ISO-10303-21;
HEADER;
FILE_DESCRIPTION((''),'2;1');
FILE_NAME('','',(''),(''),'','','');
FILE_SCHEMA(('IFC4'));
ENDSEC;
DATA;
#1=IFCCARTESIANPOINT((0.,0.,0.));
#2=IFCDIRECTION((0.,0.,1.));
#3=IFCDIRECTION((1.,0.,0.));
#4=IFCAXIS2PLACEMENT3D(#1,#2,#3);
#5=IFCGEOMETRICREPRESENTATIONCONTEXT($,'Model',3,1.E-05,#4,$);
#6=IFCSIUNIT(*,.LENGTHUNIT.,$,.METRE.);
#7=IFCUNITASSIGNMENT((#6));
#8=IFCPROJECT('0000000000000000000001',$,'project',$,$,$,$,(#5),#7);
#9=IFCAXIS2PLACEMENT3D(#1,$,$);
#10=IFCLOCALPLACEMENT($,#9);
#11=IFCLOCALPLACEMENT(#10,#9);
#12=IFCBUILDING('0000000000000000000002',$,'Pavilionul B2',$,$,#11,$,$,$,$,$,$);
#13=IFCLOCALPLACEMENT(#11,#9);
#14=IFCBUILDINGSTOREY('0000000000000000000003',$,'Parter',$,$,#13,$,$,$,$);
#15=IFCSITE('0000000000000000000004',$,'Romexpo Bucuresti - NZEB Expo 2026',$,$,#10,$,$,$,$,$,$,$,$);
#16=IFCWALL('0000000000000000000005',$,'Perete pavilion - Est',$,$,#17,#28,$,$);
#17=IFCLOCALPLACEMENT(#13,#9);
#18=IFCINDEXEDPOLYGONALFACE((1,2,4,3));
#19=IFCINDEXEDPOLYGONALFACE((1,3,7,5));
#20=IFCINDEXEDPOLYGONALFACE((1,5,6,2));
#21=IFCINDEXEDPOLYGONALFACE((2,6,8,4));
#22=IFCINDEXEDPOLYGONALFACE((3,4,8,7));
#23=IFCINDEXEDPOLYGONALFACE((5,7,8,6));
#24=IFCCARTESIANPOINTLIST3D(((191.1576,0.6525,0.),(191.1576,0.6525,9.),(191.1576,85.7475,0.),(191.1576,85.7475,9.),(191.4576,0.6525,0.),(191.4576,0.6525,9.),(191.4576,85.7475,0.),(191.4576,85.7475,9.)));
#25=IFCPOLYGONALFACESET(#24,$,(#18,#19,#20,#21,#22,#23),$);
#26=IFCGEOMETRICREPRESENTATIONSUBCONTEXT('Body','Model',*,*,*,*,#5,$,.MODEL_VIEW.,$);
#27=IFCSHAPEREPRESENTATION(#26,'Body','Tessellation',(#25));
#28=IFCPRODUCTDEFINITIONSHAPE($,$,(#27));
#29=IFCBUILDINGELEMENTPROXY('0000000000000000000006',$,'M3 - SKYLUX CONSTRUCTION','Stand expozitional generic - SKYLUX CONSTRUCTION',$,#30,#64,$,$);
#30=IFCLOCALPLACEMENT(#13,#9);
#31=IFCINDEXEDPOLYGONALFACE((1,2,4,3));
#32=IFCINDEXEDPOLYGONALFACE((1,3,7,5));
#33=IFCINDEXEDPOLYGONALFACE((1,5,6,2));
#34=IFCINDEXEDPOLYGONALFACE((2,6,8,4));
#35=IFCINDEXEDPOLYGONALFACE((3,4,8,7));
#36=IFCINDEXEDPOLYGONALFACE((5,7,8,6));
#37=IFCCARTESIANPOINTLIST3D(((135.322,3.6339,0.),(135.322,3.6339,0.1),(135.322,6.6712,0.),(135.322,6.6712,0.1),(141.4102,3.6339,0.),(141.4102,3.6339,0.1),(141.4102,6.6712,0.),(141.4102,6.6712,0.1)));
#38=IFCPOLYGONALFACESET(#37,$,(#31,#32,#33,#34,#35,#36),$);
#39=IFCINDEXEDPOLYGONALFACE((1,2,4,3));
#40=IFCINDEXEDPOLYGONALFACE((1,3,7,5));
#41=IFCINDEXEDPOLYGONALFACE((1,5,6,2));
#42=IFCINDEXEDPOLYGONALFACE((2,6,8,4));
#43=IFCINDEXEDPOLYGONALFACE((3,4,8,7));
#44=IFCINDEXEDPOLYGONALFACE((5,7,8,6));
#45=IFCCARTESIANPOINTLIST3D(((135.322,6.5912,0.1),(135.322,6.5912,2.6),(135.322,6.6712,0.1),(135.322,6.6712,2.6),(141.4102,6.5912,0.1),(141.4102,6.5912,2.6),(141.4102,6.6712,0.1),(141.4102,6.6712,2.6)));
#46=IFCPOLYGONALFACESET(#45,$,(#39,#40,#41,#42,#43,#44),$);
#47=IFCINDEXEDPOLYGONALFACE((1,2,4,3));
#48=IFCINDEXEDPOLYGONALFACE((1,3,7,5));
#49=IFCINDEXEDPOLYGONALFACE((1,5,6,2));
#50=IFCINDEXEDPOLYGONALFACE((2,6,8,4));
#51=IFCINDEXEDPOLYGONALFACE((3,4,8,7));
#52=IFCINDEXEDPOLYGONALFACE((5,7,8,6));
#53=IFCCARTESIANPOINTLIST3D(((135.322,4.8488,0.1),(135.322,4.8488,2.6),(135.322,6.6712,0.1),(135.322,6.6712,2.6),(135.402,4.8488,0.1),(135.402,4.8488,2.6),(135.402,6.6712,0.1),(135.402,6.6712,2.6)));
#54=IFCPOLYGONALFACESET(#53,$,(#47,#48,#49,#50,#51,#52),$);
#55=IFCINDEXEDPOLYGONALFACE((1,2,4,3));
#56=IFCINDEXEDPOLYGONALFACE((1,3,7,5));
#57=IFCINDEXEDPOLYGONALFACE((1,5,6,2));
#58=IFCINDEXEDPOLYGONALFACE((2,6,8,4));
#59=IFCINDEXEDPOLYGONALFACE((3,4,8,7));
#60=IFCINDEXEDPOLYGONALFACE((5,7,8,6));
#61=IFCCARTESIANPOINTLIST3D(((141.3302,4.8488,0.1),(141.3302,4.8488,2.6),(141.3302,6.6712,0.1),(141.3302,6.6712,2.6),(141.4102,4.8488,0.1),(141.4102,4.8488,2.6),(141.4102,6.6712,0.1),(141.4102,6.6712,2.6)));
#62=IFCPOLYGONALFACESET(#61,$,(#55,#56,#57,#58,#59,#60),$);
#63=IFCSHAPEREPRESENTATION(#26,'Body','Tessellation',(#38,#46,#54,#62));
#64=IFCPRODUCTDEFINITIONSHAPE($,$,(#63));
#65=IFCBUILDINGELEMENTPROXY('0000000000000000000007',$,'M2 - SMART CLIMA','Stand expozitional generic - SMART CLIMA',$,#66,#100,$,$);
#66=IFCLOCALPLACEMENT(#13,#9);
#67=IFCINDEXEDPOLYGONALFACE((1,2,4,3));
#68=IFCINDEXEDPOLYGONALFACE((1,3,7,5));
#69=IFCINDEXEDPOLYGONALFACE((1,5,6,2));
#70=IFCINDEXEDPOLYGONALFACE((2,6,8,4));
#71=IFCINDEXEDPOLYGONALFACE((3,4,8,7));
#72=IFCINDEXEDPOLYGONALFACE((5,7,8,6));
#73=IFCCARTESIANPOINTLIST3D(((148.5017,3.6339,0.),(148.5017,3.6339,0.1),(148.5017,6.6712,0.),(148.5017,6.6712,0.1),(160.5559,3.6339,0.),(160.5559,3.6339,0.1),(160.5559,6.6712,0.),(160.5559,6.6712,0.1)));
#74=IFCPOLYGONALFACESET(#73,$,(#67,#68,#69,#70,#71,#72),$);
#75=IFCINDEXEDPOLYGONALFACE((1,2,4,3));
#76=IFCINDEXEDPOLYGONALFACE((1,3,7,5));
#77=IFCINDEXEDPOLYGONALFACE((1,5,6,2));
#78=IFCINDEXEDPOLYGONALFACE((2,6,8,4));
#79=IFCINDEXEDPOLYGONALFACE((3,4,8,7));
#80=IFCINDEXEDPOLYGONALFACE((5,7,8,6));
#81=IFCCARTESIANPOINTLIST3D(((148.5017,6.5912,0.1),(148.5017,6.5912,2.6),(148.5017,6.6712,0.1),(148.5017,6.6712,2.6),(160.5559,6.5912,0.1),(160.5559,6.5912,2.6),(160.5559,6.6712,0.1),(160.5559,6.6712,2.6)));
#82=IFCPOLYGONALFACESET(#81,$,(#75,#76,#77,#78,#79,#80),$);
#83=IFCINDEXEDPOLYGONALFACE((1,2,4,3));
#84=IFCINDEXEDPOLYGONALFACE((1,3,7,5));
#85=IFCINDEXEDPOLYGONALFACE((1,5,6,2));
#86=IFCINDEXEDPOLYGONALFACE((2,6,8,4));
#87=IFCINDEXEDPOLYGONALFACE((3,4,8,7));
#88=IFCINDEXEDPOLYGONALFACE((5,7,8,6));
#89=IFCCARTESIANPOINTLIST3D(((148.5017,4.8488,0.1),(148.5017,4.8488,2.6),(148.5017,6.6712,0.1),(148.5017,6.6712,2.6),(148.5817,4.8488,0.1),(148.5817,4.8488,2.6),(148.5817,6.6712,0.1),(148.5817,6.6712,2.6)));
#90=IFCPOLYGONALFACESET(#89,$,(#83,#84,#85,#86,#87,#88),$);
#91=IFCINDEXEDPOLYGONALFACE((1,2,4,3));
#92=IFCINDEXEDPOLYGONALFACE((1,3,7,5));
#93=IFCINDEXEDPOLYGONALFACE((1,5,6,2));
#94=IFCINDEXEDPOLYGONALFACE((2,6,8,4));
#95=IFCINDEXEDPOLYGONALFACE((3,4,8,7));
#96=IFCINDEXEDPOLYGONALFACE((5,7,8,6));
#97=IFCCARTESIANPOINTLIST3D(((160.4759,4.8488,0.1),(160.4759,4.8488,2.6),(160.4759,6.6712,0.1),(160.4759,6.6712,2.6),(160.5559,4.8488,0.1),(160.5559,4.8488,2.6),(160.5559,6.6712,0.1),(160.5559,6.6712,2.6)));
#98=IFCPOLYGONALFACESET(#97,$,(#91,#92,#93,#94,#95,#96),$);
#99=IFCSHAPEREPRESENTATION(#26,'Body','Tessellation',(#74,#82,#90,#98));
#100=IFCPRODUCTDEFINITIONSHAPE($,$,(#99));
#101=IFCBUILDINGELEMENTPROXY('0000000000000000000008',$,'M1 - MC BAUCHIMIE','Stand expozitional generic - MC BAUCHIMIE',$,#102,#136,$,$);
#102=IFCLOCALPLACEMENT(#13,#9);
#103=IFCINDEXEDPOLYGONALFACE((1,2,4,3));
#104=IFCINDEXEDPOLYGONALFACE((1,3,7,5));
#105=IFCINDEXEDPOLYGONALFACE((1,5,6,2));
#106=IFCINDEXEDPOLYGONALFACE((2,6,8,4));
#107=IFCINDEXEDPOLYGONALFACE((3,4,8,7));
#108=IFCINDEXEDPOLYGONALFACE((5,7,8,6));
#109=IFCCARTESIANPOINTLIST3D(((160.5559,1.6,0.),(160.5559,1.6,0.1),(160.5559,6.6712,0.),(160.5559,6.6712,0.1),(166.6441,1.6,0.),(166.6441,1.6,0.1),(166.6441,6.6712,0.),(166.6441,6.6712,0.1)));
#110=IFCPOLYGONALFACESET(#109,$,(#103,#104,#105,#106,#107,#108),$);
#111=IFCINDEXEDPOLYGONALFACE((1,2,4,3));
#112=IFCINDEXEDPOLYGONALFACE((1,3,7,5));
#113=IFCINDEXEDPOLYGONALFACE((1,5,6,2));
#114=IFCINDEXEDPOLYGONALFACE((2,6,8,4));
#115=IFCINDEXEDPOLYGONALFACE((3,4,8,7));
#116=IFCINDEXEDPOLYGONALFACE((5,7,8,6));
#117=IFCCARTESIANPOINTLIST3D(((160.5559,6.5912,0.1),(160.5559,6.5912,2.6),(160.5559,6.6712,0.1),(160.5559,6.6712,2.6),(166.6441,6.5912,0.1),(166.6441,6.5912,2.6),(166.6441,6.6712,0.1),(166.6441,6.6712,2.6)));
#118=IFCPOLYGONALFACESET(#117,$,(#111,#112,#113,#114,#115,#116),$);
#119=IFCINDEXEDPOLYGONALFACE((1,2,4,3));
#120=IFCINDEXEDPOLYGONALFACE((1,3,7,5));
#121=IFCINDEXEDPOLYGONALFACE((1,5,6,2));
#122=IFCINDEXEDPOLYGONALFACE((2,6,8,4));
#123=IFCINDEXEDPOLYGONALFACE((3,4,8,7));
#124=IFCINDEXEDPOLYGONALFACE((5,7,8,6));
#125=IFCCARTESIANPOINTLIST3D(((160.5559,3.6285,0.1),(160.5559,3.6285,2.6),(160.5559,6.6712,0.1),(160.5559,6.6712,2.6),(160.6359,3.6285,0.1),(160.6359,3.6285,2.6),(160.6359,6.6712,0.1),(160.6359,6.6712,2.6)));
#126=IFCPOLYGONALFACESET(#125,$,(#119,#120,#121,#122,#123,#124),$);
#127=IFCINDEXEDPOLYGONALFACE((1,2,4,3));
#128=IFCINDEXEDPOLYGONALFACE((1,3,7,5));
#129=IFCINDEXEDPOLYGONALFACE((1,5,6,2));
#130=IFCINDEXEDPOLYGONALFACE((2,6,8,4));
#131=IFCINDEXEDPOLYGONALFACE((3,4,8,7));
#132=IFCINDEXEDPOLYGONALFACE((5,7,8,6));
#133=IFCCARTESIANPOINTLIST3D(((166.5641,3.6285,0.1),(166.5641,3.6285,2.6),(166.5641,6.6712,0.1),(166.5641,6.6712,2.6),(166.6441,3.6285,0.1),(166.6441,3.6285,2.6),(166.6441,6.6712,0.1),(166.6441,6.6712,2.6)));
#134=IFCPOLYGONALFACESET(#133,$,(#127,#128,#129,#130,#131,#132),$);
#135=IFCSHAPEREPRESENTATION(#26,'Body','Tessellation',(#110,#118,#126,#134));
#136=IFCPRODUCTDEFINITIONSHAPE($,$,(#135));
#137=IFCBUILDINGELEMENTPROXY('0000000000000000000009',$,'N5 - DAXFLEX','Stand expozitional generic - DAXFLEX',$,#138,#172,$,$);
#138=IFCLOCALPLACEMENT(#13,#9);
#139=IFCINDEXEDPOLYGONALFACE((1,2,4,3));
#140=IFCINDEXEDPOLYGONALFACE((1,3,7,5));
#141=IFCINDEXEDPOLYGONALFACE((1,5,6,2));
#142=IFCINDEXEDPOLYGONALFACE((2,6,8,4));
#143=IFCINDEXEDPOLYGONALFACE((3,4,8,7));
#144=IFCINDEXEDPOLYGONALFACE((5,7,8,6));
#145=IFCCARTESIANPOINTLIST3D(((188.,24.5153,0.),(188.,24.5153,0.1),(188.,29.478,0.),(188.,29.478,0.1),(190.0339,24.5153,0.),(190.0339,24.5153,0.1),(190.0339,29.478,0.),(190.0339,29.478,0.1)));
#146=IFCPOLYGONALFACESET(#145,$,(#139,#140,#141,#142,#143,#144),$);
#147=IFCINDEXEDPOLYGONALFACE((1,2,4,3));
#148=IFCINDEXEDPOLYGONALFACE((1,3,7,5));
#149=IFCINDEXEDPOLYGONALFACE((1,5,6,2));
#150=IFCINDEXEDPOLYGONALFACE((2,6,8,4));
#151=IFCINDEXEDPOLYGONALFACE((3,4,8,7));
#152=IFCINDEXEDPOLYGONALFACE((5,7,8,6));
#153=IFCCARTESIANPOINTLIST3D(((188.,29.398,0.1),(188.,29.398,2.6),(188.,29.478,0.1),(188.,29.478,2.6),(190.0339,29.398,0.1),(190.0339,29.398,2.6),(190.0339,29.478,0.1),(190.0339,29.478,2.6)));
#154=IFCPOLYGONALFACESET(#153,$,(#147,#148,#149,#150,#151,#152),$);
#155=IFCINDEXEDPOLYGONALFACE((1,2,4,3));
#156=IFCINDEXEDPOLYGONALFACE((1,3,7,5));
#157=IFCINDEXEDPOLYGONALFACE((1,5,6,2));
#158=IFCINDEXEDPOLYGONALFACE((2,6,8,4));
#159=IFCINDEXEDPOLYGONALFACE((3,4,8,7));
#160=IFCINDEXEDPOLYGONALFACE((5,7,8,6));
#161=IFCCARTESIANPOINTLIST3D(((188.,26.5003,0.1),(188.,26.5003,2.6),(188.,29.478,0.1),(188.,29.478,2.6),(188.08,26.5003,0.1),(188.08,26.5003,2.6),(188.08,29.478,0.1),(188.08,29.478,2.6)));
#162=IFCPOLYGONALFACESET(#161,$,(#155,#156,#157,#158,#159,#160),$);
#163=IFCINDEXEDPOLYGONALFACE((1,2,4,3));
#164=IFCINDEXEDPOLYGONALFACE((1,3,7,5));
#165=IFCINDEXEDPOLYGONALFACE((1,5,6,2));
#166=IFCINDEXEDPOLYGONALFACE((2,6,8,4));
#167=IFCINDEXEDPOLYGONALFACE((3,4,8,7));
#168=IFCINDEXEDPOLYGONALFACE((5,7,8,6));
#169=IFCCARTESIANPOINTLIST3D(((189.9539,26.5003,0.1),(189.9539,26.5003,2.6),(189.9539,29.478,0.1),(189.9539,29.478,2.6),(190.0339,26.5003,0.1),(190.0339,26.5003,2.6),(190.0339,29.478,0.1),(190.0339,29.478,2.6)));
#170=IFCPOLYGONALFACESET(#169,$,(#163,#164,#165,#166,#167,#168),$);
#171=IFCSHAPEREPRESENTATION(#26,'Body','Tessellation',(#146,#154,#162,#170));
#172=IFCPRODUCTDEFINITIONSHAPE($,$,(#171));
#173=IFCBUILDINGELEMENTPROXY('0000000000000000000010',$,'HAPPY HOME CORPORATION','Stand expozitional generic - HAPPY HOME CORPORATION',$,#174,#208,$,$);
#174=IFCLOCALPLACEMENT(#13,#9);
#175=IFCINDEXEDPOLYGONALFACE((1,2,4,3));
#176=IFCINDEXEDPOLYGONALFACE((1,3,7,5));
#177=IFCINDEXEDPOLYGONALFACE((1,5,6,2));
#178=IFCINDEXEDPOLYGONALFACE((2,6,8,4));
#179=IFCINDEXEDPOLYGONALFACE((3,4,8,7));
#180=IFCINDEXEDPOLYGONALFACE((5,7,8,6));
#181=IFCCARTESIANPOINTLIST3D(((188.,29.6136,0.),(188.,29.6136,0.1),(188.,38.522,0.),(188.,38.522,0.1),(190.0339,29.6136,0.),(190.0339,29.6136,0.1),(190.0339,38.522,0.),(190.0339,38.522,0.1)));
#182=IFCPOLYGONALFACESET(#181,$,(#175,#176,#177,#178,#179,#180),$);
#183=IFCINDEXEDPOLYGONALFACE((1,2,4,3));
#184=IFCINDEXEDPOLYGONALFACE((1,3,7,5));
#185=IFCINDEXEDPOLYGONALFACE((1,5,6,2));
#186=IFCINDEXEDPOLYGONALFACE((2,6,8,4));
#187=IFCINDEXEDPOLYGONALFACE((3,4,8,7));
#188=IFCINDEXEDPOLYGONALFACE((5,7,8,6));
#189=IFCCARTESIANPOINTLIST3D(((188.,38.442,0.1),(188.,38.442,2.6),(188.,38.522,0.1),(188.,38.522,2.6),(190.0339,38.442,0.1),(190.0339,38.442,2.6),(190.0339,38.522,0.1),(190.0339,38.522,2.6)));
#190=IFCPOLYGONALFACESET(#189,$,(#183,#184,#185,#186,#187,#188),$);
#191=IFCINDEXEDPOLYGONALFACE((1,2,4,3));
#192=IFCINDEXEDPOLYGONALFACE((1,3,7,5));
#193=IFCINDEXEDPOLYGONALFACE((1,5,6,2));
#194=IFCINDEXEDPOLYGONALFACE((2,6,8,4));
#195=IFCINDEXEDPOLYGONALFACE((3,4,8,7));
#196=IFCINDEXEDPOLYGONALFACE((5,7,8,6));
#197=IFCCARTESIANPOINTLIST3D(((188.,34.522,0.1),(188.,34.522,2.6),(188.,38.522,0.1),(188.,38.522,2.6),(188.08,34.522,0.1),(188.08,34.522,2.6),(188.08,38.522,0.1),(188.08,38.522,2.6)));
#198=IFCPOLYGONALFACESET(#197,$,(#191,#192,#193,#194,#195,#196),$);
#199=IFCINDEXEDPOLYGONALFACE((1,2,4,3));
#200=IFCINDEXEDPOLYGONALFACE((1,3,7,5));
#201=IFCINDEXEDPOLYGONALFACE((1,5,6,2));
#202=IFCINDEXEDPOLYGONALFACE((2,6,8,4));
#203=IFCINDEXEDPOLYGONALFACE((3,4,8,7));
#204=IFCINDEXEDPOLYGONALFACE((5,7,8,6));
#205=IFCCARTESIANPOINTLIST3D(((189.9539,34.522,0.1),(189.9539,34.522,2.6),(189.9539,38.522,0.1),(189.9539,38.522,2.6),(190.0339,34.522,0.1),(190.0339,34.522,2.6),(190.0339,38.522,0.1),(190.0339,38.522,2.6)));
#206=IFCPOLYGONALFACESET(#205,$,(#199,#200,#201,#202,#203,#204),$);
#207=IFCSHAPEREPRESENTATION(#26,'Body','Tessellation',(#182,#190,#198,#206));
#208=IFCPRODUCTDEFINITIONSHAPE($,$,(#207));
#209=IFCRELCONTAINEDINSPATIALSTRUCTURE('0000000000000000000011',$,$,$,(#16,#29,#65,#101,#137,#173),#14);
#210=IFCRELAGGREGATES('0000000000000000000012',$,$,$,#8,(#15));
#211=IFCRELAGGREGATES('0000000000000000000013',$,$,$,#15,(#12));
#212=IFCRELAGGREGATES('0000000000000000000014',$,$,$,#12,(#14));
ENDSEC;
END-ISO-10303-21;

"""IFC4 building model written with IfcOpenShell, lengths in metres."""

from ifc_helpers import new_model, si_unit, frame, frame_2d, origin, origin_with_axes, place, context, subcontext, project, spatial, rectangle, extrude, element, save


model = new_model("IFC4")

# Units and contexts
model_context = context("Model", 3, precision=1e-05, world=origin_with_axes())
body_context = subcontext(model_context, "Body", "Model", "MODEL_VIEW")
ifc_project = project(units=[si_unit("LENGTHUNIT", "METRE")], contexts=[model_context])

# Site, building, storey
site_placement = place(None, origin())
site = spatial("IfcSite", under=ifc_project, at=site_placement, Name="Romexpo Bucuresti - NZEB Expo 2026")
building_placement = place(site_placement, origin())
building = spatial("IfcBuilding", under=site, at=building_placement, Name="Pavilionul B2")
storey_placement = place(building_placement, origin())
storey = spatial("IfcBuildingStorey", under=building, at=storey_placement, Name="Parter")

# Wall
wall_placement = place(storey_placement, frame((191.1576, 0.6525, 0.0), z_axis=(0.0, 0.0, 1.0), x_axis=(1.0, 0.0, 0.0)))
element("IfcWall", 1, at=wall_placement, inside=storey, Name="Perete pavilion - Est", context=body_context, shape_type="SweptSolid", body=[
    extrude(rectangle(XDim=0.3, YDim=85.0949, at=frame_2d((0.15, 42.5475))), origin(), (0.0, 0.0, 1.0), 9.0),
])

# Building element proxies
proxy_1_placement = place(storey_placement, frame((135.322, 3.6339, 0.0), z_axis=(0.0, 0.0, 1.0), x_axis=(1.0, 0.0, 0.0)))
element("IfcBuildingElementProxy", 2, at=proxy_1_placement, inside=storey, Name="M3 - SKYLUX CONSTRUCTION", Description="Stand expozitional generic - SKYLUX CONSTRUCTION", context=body_context, shape_type="SweptSolid", body=[
    extrude(rectangle(XDim=6.0881, YDim=3.0373, at=frame_2d((3.0441, 1.5186))), origin(), (0.0, 0.0, 1.0), 0.1),
    extrude(rectangle(XDim=6.0881, YDim=0.08, at=frame_2d((3.0441, 2.9973))), frame((0.0, 0.0, 0.1)), (0.0, 0.0, 1.0), 2.5),
    extrude(rectangle(XDim=0.08, YDim=1.8224, at=frame_2d((0.04, 2.1261))), frame((0.0, 0.0, 0.1)), (0.0, 0.0, 1.0), 2.5),
    extrude(rectangle(XDim=0.08, YDim=1.8224, at=frame_2d((6.0481, 2.1261))), frame((0.0, 0.0, 0.1)), (0.0, 0.0, 1.0), 2.5),
])
proxy_2_placement = place(storey_placement, frame((148.5017, 3.6339, 0.0), z_axis=(0.0, 0.0, 1.0), x_axis=(1.0, 0.0, 0.0)))
element("IfcBuildingElementProxy", 3, at=proxy_2_placement, inside=storey, Name="M2 - SMART CLIMA", Description="Stand expozitional generic - SMART CLIMA", context=body_context, shape_type="SweptSolid", body=[
    extrude(rectangle(XDim=12.0542, YDim=3.0373, at=frame_2d((6.0271, 1.5186))), origin(), (0.0, 0.0, 1.0), 0.1),
    extrude(rectangle(XDim=12.0542, YDim=0.08, at=frame_2d((6.0271, 2.9973))), frame((0.0, 0.0, 0.1)), (0.0, 0.0, 1.0), 2.5),
    extrude(rectangle(XDim=0.08, YDim=1.8224, at=frame_2d((0.04, 2.1261))), frame((0.0, 0.0, 0.1)), (0.0, 0.0, 1.0), 2.5),
    extrude(rectangle(XDim=0.08, YDim=1.8224, at=frame_2d((12.0142, 2.1261))), frame((0.0, 0.0, 0.1)), (0.0, 0.0, 1.0), 2.5),
])
proxy_3_placement = place(storey_placement, frame((160.5559, 1.6, 0.0), z_axis=(0.0, 0.0, 1.0), x_axis=(1.0, 0.0, 0.0)))
element("IfcBuildingElementProxy", 4, at=proxy_3_placement, inside=storey, Name="M1 - MC BAUCHIMIE", Description="Stand expozitional generic - MC BAUCHIMIE", context=body_context, shape_type="SweptSolid", body=[
    extrude(rectangle(XDim=6.0881, YDim=5.0712, at=frame_2d((3.0441, 2.5356))), origin(), (0.0, 0.0, 1.0), 0.1),
    extrude(rectangle(XDim=6.0881, YDim=0.08, at=frame_2d((3.0441, 5.0312))), frame((0.0, 0.0, 0.1)), (0.0, 0.0, 1.0), 2.5),
    extrude(rectangle(XDim=0.08, YDim=3.0427, at=frame_2d((0.04, 3.5498))), frame((0.0, 0.0, 0.1)), (0.0, 0.0, 1.0), 2.5),
    extrude(rectangle(XDim=0.08, YDim=3.0427, at=frame_2d((6.0481, 3.5498))), frame((0.0, 0.0, 0.1)), (0.0, 0.0, 1.0), 2.5),
])
proxy_4_placement = place(storey_placement, frame((188.0, 24.5153, 0.0), z_axis=(0.0, 0.0, 1.0), x_axis=(1.0, 0.0, 0.0)))
element("IfcBuildingElementProxy", 5, at=proxy_4_placement, inside=storey, Name="N5 - DAXFLEX", Description="Stand expozitional generic - DAXFLEX", context=body_context, shape_type="SweptSolid", body=[
    extrude(rectangle(XDim=2.0339, YDim=4.9627, at=frame_2d((1.0169, 2.4814))), origin(), (0.0, 0.0, 1.0), 0.1),
    extrude(rectangle(XDim=2.0339, YDim=0.08, at=frame_2d((1.0169, 4.9227))), frame((0.0, 0.0, 0.1)), (0.0, 0.0, 1.0), 2.5),
    extrude(rectangle(XDim=0.08, YDim=2.9776, at=frame_2d((0.04, 3.4739))), frame((0.0, 0.0, 0.1)), (0.0, 0.0, 1.0), 2.5),
    extrude(rectangle(XDim=0.08, YDim=2.9776, at=frame_2d((1.9939, 3.4739))), frame((0.0, 0.0, 0.1)), (0.0, 0.0, 1.0), 2.5),
])
proxy_5_placement = place(storey_placement, frame((188.0, 29.6136, 0.0), z_axis=(0.0, 0.0, 1.0), x_axis=(1.0, 0.0, 0.0)))
element("IfcBuildingElementProxy", 6, at=proxy_5_placement, inside=storey, Name="HAPPY HOME CORPORATION", Description="Stand expozitional generic - HAPPY HOME CORPORATION", context=body_context, shape_type="SweptSolid", body=[
    extrude(rectangle(XDim=2.0339, YDim=8.9085, at=frame_2d((1.0169, 4.4542))), origin(), (0.0, 0.0, 1.0), 0.1),
    extrude(rectangle(XDim=2.0339, YDim=0.08, at=frame_2d((1.0169, 8.8685))), frame((0.0, 0.0, 0.1)), (0.0, 0.0, 1.0), 2.5),
    extrude(rectangle(XDim=0.08, YDim=4.0, at=frame_2d((0.04, 6.9085))), frame((0.0, 0.0, 0.1)), (0.0, 0.0, 1.0), 2.5),
    extrude(rectangle(XDim=0.08, YDim=4.0, at=frame_2d((1.9939, 6.9085))), frame((0.0, 0.0, 0.1)), (0.0, 0.0, 1.0), 2.5),
])

save(model, "model.ifc")
